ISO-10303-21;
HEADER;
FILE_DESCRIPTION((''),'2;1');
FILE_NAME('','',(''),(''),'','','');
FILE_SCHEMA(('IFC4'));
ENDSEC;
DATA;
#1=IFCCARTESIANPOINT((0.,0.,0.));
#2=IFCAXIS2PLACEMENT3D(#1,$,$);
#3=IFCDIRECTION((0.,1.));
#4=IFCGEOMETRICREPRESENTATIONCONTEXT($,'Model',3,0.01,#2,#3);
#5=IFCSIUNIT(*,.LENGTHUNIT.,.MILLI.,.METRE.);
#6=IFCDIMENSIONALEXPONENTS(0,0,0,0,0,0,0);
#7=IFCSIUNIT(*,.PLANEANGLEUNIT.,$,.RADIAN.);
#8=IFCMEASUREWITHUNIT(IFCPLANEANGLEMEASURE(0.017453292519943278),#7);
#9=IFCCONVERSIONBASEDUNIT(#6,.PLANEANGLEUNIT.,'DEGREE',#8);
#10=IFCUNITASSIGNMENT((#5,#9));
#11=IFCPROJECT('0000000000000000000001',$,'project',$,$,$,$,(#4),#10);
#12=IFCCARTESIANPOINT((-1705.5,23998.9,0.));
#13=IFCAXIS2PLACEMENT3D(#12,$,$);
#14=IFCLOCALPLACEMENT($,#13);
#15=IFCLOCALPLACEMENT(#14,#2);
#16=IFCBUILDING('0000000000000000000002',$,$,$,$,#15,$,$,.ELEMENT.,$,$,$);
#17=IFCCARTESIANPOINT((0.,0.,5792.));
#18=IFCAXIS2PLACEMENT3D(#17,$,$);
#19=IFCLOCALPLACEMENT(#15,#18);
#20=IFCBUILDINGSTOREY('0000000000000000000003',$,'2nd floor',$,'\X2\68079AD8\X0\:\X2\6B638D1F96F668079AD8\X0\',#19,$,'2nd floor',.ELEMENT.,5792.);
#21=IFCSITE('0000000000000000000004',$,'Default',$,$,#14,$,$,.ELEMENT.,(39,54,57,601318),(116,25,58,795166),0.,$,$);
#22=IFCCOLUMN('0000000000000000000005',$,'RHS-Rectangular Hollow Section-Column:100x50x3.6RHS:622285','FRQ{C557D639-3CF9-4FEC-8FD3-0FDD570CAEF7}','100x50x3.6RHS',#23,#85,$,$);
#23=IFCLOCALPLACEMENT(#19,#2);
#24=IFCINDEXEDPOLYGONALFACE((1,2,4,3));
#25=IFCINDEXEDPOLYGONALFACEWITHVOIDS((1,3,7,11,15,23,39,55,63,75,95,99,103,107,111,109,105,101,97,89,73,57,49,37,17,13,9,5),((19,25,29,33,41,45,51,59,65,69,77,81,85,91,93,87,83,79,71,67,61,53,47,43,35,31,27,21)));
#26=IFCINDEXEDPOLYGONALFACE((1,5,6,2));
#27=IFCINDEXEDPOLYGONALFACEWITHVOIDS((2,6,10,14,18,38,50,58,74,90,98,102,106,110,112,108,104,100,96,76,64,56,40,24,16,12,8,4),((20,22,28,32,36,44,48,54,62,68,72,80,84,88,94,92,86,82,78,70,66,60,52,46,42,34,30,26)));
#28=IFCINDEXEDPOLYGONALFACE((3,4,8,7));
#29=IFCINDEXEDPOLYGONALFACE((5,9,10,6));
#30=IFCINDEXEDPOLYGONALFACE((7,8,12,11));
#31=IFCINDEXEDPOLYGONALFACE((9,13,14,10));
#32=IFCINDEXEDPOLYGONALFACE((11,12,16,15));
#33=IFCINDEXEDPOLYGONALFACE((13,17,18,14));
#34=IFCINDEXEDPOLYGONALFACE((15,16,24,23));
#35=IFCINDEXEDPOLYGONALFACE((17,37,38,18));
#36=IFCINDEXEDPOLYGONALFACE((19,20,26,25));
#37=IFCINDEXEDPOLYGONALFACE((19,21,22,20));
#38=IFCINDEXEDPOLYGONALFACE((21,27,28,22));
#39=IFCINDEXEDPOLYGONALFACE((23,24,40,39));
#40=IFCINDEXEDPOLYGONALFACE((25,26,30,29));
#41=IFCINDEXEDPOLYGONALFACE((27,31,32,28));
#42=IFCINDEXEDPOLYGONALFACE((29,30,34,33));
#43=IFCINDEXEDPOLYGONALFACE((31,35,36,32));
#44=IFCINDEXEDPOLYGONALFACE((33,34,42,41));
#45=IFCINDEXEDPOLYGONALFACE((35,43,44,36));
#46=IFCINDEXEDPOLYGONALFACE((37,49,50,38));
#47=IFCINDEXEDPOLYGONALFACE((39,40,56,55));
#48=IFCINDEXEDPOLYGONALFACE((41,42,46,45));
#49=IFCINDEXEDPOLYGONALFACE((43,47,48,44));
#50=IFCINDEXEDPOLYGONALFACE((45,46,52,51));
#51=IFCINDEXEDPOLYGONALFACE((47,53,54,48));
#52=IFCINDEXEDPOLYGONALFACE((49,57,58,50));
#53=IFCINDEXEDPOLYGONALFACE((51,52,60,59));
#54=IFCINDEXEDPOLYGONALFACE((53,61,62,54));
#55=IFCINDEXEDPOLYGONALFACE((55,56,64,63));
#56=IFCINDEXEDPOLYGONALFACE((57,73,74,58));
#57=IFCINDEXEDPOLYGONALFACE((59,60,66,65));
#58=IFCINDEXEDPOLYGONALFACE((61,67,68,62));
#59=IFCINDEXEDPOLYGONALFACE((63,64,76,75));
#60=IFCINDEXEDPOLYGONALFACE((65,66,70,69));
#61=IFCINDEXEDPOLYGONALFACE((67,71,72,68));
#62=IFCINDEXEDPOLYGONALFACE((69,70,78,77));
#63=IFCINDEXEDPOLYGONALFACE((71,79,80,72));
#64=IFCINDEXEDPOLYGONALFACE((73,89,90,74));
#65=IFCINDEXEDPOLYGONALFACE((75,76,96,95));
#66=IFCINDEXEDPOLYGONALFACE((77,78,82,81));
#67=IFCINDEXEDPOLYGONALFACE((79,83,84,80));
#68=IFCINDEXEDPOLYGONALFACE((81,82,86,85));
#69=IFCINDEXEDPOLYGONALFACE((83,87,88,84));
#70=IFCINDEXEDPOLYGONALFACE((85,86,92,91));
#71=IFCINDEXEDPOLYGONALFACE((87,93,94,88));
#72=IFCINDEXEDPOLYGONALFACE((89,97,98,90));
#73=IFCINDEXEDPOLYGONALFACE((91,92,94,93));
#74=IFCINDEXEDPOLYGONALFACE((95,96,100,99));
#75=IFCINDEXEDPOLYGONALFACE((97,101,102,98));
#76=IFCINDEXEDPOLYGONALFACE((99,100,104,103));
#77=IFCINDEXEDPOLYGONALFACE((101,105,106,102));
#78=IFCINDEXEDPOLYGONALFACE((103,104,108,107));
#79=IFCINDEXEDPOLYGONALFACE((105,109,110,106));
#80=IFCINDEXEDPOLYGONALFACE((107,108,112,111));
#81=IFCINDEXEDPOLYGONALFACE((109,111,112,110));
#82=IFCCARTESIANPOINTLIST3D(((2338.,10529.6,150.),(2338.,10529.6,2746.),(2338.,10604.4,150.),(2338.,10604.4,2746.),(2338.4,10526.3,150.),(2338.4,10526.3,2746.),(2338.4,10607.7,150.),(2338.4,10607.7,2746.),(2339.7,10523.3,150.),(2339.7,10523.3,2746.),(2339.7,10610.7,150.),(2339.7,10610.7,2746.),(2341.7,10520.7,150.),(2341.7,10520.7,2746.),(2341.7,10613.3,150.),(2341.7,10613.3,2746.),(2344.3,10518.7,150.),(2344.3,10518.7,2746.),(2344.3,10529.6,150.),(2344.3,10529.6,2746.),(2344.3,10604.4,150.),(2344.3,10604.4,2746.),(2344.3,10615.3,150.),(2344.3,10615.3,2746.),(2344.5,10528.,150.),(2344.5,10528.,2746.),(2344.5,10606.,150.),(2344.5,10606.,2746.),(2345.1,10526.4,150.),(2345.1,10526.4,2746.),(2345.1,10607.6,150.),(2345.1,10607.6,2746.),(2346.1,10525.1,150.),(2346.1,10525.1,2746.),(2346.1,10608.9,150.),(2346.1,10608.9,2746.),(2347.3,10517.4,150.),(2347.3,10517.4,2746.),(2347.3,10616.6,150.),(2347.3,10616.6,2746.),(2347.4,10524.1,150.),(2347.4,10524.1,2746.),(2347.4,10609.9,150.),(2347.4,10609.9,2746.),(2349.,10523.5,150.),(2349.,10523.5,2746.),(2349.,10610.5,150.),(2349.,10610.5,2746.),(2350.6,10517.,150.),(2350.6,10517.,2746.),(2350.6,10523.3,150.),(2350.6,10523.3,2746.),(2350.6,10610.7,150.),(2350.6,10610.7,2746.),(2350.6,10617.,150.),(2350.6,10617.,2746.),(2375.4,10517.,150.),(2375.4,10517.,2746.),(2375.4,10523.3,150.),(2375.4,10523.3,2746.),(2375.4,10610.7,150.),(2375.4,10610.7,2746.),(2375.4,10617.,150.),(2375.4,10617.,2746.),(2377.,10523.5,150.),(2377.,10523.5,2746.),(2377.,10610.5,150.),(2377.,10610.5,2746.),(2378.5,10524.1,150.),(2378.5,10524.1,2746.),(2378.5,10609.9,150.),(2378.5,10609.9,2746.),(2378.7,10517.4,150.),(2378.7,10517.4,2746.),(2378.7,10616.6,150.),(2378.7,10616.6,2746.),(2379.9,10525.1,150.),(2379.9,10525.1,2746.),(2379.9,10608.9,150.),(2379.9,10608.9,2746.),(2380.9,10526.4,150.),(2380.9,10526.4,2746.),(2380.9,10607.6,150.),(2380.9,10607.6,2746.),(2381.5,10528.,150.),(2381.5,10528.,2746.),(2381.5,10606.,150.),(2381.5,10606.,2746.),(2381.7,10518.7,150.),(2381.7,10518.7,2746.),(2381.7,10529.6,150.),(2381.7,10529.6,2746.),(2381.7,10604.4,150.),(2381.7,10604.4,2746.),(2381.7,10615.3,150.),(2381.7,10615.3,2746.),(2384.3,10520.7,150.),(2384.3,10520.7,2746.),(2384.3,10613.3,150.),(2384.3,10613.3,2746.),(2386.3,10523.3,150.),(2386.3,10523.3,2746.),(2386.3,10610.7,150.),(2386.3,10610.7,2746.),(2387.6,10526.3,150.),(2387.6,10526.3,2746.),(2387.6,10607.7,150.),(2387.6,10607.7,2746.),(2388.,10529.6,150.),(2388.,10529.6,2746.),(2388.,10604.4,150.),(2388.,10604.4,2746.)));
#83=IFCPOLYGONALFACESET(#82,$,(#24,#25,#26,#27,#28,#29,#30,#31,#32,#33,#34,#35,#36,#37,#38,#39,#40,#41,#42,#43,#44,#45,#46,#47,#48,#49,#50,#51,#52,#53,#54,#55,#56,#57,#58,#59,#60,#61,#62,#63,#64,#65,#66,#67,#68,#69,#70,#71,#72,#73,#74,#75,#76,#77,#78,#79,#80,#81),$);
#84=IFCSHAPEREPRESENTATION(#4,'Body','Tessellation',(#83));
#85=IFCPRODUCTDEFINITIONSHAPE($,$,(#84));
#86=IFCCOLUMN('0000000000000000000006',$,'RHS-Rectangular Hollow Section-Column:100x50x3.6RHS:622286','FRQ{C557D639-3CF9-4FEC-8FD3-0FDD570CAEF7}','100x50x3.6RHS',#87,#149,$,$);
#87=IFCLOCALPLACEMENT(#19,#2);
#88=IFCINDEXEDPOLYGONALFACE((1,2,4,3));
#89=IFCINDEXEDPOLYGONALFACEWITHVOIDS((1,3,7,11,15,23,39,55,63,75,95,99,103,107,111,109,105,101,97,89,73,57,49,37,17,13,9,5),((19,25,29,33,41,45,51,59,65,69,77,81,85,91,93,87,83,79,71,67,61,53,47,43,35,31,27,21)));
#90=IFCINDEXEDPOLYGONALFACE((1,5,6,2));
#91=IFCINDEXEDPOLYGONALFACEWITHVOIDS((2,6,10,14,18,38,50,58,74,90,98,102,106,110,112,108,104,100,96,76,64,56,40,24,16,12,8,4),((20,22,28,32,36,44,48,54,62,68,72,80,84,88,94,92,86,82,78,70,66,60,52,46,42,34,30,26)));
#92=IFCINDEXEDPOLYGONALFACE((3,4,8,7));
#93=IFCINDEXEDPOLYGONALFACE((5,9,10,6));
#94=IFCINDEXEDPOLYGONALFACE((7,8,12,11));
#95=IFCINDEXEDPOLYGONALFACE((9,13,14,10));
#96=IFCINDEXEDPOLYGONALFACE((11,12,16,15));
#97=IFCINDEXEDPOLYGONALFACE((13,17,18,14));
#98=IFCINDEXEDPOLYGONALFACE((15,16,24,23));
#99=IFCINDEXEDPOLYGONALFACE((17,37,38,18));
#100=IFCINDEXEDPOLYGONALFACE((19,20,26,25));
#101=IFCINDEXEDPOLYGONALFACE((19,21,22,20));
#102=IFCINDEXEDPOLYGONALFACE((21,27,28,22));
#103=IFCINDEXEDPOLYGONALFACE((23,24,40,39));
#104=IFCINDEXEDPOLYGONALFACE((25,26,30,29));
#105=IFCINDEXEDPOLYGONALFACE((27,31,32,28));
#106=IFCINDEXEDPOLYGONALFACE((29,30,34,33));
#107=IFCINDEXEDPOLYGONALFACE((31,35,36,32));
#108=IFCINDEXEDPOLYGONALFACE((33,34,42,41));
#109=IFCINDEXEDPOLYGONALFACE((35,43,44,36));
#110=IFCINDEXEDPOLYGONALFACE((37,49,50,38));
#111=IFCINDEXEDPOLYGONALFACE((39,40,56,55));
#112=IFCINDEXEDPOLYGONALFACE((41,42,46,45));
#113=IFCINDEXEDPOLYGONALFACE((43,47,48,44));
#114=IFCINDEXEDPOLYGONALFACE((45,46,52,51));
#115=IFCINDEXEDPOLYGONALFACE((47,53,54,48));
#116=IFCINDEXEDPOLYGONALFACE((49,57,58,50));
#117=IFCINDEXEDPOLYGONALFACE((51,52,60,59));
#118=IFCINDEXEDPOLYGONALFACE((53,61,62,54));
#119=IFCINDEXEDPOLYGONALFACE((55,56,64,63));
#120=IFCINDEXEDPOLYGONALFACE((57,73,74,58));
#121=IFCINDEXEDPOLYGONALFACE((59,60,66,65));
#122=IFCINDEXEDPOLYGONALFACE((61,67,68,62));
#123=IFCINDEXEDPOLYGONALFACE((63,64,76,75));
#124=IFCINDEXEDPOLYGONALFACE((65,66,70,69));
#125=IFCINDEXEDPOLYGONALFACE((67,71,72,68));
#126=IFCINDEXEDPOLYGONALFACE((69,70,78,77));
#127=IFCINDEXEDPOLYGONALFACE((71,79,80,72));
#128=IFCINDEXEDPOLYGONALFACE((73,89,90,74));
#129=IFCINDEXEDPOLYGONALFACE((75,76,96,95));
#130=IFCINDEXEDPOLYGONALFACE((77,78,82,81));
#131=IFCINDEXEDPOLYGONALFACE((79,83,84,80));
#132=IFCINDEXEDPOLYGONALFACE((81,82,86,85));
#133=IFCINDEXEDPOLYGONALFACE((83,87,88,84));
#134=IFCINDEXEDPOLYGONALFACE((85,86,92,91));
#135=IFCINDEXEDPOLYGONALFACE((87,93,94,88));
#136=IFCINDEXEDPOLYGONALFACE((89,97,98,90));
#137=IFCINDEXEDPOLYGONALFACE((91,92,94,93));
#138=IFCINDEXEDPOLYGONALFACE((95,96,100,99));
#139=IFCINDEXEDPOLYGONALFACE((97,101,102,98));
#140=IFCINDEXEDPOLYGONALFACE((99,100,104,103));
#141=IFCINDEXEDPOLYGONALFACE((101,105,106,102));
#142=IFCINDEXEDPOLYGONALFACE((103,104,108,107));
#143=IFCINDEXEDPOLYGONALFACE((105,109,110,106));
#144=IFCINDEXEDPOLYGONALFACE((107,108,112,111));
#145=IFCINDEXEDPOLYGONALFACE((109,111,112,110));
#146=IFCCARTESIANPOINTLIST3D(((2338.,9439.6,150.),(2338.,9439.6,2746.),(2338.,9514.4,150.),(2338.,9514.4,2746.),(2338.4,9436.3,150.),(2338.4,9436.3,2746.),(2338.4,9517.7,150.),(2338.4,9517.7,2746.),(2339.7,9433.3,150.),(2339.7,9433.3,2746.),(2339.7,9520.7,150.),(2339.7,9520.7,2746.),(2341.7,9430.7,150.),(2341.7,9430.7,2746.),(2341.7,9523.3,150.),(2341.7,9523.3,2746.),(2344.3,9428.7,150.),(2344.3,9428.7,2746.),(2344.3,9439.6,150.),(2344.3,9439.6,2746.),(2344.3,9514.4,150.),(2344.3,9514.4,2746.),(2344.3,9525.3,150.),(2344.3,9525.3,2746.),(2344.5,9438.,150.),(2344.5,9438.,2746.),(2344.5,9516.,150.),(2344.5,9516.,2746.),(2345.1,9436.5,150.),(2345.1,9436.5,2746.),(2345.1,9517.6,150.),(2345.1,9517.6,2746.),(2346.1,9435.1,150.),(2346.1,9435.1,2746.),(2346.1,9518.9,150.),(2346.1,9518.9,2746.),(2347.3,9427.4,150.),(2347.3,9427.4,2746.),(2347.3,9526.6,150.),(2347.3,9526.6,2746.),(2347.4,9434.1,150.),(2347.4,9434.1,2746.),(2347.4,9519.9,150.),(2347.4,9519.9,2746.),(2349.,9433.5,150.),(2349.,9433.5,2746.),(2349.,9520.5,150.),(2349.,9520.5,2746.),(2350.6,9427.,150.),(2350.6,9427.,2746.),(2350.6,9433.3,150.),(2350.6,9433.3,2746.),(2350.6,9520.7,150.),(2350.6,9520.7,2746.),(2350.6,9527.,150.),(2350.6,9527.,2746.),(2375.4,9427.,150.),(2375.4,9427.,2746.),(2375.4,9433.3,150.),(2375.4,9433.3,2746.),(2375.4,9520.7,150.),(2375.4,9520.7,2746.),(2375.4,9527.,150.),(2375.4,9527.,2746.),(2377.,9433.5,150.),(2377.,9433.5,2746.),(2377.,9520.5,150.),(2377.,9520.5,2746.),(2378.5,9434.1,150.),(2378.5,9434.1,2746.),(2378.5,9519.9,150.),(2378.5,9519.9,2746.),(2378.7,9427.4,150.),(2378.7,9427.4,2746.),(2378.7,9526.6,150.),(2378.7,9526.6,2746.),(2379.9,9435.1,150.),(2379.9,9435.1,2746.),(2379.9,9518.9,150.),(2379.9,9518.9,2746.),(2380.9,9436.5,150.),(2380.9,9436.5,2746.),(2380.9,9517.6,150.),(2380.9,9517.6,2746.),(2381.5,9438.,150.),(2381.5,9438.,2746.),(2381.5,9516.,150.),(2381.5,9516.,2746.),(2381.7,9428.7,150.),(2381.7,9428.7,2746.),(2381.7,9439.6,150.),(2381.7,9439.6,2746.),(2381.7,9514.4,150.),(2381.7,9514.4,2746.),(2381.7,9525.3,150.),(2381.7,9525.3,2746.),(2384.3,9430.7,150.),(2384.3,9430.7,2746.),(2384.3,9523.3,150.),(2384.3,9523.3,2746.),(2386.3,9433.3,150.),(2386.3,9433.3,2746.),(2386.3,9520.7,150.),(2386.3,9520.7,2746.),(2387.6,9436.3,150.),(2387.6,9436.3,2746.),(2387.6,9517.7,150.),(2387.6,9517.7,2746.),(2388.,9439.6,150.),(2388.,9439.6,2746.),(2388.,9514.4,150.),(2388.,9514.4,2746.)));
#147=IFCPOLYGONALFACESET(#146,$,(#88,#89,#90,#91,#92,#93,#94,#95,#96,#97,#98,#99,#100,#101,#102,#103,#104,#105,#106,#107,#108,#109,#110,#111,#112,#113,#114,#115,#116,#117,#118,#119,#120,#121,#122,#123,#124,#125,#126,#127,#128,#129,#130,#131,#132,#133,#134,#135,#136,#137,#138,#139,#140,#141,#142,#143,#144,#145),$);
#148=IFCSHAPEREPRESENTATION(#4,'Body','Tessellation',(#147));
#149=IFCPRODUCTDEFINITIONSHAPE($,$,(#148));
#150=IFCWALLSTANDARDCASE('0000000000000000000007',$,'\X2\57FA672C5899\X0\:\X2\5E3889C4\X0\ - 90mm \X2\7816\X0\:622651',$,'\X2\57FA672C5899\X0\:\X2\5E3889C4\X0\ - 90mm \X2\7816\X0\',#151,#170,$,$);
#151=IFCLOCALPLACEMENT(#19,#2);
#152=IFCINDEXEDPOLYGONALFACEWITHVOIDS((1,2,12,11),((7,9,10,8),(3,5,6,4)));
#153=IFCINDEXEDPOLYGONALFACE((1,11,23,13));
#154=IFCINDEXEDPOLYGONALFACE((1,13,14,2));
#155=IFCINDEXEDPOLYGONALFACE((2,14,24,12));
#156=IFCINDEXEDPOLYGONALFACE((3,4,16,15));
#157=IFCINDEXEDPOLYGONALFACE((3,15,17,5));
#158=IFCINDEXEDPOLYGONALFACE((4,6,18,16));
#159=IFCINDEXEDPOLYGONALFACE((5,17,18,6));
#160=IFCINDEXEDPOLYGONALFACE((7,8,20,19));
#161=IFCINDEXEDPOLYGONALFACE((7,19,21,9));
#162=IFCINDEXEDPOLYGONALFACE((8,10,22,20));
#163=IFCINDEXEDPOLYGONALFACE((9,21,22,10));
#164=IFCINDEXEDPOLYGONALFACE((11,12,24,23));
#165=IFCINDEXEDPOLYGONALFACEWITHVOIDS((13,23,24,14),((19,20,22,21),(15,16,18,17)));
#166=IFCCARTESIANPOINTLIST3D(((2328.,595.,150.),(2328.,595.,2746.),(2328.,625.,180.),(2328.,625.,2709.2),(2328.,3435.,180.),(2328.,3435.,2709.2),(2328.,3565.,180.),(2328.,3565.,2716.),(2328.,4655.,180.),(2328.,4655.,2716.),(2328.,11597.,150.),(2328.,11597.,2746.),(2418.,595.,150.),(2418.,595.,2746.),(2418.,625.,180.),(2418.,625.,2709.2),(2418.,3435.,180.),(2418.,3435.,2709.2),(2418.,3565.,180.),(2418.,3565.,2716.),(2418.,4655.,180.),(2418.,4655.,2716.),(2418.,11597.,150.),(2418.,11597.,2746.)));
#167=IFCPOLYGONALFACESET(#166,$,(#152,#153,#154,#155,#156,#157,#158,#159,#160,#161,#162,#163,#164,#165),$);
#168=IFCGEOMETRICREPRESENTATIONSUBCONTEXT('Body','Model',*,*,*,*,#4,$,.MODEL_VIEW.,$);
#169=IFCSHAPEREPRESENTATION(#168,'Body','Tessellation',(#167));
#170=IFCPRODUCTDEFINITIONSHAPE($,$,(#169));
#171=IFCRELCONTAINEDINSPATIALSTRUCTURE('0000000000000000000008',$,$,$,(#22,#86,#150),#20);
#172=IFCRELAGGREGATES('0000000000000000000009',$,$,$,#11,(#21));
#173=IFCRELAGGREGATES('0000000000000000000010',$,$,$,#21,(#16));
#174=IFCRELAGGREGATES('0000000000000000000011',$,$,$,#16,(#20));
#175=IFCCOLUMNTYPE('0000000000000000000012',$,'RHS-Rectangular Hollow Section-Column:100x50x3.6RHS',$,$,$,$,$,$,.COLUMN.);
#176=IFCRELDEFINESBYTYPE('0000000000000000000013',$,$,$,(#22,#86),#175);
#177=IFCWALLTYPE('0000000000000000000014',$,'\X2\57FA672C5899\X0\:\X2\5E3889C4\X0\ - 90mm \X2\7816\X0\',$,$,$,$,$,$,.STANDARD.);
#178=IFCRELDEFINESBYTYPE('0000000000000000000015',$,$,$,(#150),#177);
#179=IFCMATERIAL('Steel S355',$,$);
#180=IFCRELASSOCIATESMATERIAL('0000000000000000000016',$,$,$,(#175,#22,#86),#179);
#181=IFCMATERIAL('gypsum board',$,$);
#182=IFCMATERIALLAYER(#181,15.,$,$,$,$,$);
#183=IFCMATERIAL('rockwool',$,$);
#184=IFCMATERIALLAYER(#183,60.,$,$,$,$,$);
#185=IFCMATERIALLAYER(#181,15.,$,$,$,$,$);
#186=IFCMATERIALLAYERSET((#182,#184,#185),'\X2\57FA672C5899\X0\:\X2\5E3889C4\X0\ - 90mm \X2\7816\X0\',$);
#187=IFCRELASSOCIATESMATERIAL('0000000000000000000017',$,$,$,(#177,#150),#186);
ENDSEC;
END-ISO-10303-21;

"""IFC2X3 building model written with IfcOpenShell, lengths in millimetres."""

from ifc_helpers import new_model, entity, si_unit, converted_unit, direction, frame, frame_2d, origin, origin_2d, place, context, subcontext, project, spatial, rectangle, hollow_rectangle, extrude, clip, halfspace, material, layer, layer_set, layer_usage, type_object, element, save


model = new_model("IFC2X3")

# Units and contexts
model_context = context("Model", 3, precision=0.01, world=origin(), true_north=direction((0.0, 1.0)))
body_context = subcontext(model_context, "Body", "Model", "MODEL_VIEW")
ifc_project = project(units=[si_unit("LENGTHUNIT", "METRE", prefix="MILLI"), converted_unit("PLANEANGLEUNIT", "DEGREE", entity("IfcPlaneAngleMeasure", 0.017453292519943278), si_unit("PLANEANGLEUNIT", "RADIAN"), dimensions=[0, 0, 0, 0, 0, 0, 0])], contexts=[model_context])

# Site, building, storey
site_placement = place(None, frame((-1705.5, 23998.9, 0.0)))
site = spatial("IfcSite", under=ifc_project, at=site_placement, Name="Default", CompositionType="ELEMENT", RefLatitude=(39, 54, 57, 601318), RefLongitude=(116, 25, 58, 795166), RefElevation=0.0)
building_placement = place(site_placement, origin())
building = spatial("IfcBuilding", under=site, at=building_placement, CompositionType="ELEMENT")
storey_placement = place(building_placement, frame((0.0, 0.0, 5792.0)))
storey = spatial("IfcBuildingStorey", under=building, at=storey_placement, Name="2nd floor", ObjectType="标高:正负零标高", LongName="2nd floor", CompositionType="ELEMENT", Elevation=5792.0)

# Columns
ifc_material_1 = material(Name="Steel S355")
column_type = type_object("IfcColumnType", Name="RHS-Rectangular Hollow Section-Column:100x50x3.6RHS", PredefinedType="COLUMN", material=ifc_material_1)
column_1_placement = place(storey_placement, frame((2363.0, 10567.0, 2746.0), z_axis=(0.0, 0.0, 1.0), x_axis=(-1.0, 0.0, 0.0)))
element("IfcColumn", 1, at=column_1_placement, inside=storey, type_object=column_type, material=ifc_material_1, Name="RHS-Rectangular Hollow Section-Column:100x50x3.6RHS:622285", Description="FRQ{C557D639-3CF9-4FEC-8FD3-0FDD570CAEF7}", ObjectType="100x50x3.6RHS", context=model_context, shape_type="Clipping", body=[
    clip(extrude(hollow_rectangle(XDim=50.0, YDim=100.0, WallThickness=6.3, InnerFilletRadius=6.3, OuterFilletRadius=12.6, at=origin_2d()), origin(), (0.0, 0.0, -1.0), 2651.9), halfspace(frame((2363.0, 10567.0, -2596.0), z_axis=(0.0, 0.0, 1.0), x_axis=(-1.0, 0.0, 0.0)), True)),
])
column_2_placement = place(storey_placement, frame((2363.0, 9477.0, 2746.0), z_axis=(0.0, 0.0, 1.0), x_axis=(-1.0, 0.0, 0.0)))
element("IfcColumn", 2, at=column_2_placement, inside=storey, type_object=column_type, material=ifc_material_1, Name="RHS-Rectangular Hollow Section-Column:100x50x3.6RHS:622286", Description="FRQ{C557D639-3CF9-4FEC-8FD3-0FDD570CAEF7}", ObjectType="100x50x3.6RHS", context=model_context, shape_type="Clipping", body=[
    clip(extrude(hollow_rectangle(XDim=50.0, YDim=100.0, WallThickness=6.3, InnerFilletRadius=6.3, OuterFilletRadius=12.6, at=origin_2d()), origin(), (0.0, 0.0, -1.0), 2651.9), halfspace(frame((2363.0, 9477.0, -2596.0), z_axis=(0.0, 0.0, 1.0), x_axis=(-1.0, 0.0, 0.0)), True)),
])

# Wall, openings
ifc_material_2 = material(Name="gypsum board")
ifc_layer_1 = layer(ifc_material_2, 15.0)
ifc_material_3 = material(Name="rockwool")
ifc_layer_2 = layer(ifc_material_3, 60.0)
ifc_layer_3 = layer(ifc_material_2, 15.0)
ifc_layer_set = layer_set([ifc_layer_1, ifc_layer_2, ifc_layer_3], Name="基本墙:常规 - 90mm 砖")
ifc_layer_usage = layer_usage(ifc_layer_set, "AXIS2", "NEGATIVE", 45.0)
wall_type = type_object("IfcWallType", Name="基本墙:常规 - 90mm 砖", PredefinedType="STANDARD", material=ifc_layer_set)
wall_placement = place(storey_placement, frame((2373.0, 11597.0, 150.0), z_axis=(0.0, 0.0, 1.0), x_axis=(0.0, -1.0, 0.0)))
wall = element("IfcWallStandardCase", 3, at=wall_placement, inside=storey, type_object=wall_type, material=ifc_layer_usage, Name="基本墙:常规 - 90mm 砖:622651", ObjectType="基本墙:常规 - 90mm 砖", context=body_context, shape_type="SweptSolid", body=[
    extrude(rectangle(XDim=11002.0, YDim=90.0, at=frame_2d((5501.0, 0.0), x_axis=(-1.0, 0.0))), origin(), (0.0, 0.0, 1.0), 2596.0),
])
opening_1_placement = place(wall_placement, origin())
element("IfcOpeningElement", 4, at=opening_1_placement, cuts=wall, ObjectType="Opening", context=body_context, shape_type="SweptSolid", body=[
    extrude(rectangle(XDim=2536.0, YDim=1090.0, at=frame_2d((0.0, 0.0), x_axis=(0.0, 1.0))), frame((7487.0, 45.0, 1298.0), z_axis=(0.0, -1.0, 0.0), x_axis=(-1.0, 0.0, 0.0)), (0.0, 0.0, 1.0), 90.0),
])
opening_2_placement = place(wall_placement, origin())
element("IfcOpeningElement", 5, at=opening_2_placement, cuts=wall, ObjectType="Opening", context=body_context, shape_type="SweptSolid", body=[
    extrude(rectangle(XDim=2529.2, YDim=2810.0, at=frame_2d((0.0, 0.0), x_axis=(0.0, 1.0))), frame((9567.0, 45.0, 1294.6), z_axis=(0.0, -1.0, 0.0), x_axis=(-1.0, 0.0, 0.0)), (0.0, 0.0, 1.0), 90.0),
])

save(model, "model.ifc")
